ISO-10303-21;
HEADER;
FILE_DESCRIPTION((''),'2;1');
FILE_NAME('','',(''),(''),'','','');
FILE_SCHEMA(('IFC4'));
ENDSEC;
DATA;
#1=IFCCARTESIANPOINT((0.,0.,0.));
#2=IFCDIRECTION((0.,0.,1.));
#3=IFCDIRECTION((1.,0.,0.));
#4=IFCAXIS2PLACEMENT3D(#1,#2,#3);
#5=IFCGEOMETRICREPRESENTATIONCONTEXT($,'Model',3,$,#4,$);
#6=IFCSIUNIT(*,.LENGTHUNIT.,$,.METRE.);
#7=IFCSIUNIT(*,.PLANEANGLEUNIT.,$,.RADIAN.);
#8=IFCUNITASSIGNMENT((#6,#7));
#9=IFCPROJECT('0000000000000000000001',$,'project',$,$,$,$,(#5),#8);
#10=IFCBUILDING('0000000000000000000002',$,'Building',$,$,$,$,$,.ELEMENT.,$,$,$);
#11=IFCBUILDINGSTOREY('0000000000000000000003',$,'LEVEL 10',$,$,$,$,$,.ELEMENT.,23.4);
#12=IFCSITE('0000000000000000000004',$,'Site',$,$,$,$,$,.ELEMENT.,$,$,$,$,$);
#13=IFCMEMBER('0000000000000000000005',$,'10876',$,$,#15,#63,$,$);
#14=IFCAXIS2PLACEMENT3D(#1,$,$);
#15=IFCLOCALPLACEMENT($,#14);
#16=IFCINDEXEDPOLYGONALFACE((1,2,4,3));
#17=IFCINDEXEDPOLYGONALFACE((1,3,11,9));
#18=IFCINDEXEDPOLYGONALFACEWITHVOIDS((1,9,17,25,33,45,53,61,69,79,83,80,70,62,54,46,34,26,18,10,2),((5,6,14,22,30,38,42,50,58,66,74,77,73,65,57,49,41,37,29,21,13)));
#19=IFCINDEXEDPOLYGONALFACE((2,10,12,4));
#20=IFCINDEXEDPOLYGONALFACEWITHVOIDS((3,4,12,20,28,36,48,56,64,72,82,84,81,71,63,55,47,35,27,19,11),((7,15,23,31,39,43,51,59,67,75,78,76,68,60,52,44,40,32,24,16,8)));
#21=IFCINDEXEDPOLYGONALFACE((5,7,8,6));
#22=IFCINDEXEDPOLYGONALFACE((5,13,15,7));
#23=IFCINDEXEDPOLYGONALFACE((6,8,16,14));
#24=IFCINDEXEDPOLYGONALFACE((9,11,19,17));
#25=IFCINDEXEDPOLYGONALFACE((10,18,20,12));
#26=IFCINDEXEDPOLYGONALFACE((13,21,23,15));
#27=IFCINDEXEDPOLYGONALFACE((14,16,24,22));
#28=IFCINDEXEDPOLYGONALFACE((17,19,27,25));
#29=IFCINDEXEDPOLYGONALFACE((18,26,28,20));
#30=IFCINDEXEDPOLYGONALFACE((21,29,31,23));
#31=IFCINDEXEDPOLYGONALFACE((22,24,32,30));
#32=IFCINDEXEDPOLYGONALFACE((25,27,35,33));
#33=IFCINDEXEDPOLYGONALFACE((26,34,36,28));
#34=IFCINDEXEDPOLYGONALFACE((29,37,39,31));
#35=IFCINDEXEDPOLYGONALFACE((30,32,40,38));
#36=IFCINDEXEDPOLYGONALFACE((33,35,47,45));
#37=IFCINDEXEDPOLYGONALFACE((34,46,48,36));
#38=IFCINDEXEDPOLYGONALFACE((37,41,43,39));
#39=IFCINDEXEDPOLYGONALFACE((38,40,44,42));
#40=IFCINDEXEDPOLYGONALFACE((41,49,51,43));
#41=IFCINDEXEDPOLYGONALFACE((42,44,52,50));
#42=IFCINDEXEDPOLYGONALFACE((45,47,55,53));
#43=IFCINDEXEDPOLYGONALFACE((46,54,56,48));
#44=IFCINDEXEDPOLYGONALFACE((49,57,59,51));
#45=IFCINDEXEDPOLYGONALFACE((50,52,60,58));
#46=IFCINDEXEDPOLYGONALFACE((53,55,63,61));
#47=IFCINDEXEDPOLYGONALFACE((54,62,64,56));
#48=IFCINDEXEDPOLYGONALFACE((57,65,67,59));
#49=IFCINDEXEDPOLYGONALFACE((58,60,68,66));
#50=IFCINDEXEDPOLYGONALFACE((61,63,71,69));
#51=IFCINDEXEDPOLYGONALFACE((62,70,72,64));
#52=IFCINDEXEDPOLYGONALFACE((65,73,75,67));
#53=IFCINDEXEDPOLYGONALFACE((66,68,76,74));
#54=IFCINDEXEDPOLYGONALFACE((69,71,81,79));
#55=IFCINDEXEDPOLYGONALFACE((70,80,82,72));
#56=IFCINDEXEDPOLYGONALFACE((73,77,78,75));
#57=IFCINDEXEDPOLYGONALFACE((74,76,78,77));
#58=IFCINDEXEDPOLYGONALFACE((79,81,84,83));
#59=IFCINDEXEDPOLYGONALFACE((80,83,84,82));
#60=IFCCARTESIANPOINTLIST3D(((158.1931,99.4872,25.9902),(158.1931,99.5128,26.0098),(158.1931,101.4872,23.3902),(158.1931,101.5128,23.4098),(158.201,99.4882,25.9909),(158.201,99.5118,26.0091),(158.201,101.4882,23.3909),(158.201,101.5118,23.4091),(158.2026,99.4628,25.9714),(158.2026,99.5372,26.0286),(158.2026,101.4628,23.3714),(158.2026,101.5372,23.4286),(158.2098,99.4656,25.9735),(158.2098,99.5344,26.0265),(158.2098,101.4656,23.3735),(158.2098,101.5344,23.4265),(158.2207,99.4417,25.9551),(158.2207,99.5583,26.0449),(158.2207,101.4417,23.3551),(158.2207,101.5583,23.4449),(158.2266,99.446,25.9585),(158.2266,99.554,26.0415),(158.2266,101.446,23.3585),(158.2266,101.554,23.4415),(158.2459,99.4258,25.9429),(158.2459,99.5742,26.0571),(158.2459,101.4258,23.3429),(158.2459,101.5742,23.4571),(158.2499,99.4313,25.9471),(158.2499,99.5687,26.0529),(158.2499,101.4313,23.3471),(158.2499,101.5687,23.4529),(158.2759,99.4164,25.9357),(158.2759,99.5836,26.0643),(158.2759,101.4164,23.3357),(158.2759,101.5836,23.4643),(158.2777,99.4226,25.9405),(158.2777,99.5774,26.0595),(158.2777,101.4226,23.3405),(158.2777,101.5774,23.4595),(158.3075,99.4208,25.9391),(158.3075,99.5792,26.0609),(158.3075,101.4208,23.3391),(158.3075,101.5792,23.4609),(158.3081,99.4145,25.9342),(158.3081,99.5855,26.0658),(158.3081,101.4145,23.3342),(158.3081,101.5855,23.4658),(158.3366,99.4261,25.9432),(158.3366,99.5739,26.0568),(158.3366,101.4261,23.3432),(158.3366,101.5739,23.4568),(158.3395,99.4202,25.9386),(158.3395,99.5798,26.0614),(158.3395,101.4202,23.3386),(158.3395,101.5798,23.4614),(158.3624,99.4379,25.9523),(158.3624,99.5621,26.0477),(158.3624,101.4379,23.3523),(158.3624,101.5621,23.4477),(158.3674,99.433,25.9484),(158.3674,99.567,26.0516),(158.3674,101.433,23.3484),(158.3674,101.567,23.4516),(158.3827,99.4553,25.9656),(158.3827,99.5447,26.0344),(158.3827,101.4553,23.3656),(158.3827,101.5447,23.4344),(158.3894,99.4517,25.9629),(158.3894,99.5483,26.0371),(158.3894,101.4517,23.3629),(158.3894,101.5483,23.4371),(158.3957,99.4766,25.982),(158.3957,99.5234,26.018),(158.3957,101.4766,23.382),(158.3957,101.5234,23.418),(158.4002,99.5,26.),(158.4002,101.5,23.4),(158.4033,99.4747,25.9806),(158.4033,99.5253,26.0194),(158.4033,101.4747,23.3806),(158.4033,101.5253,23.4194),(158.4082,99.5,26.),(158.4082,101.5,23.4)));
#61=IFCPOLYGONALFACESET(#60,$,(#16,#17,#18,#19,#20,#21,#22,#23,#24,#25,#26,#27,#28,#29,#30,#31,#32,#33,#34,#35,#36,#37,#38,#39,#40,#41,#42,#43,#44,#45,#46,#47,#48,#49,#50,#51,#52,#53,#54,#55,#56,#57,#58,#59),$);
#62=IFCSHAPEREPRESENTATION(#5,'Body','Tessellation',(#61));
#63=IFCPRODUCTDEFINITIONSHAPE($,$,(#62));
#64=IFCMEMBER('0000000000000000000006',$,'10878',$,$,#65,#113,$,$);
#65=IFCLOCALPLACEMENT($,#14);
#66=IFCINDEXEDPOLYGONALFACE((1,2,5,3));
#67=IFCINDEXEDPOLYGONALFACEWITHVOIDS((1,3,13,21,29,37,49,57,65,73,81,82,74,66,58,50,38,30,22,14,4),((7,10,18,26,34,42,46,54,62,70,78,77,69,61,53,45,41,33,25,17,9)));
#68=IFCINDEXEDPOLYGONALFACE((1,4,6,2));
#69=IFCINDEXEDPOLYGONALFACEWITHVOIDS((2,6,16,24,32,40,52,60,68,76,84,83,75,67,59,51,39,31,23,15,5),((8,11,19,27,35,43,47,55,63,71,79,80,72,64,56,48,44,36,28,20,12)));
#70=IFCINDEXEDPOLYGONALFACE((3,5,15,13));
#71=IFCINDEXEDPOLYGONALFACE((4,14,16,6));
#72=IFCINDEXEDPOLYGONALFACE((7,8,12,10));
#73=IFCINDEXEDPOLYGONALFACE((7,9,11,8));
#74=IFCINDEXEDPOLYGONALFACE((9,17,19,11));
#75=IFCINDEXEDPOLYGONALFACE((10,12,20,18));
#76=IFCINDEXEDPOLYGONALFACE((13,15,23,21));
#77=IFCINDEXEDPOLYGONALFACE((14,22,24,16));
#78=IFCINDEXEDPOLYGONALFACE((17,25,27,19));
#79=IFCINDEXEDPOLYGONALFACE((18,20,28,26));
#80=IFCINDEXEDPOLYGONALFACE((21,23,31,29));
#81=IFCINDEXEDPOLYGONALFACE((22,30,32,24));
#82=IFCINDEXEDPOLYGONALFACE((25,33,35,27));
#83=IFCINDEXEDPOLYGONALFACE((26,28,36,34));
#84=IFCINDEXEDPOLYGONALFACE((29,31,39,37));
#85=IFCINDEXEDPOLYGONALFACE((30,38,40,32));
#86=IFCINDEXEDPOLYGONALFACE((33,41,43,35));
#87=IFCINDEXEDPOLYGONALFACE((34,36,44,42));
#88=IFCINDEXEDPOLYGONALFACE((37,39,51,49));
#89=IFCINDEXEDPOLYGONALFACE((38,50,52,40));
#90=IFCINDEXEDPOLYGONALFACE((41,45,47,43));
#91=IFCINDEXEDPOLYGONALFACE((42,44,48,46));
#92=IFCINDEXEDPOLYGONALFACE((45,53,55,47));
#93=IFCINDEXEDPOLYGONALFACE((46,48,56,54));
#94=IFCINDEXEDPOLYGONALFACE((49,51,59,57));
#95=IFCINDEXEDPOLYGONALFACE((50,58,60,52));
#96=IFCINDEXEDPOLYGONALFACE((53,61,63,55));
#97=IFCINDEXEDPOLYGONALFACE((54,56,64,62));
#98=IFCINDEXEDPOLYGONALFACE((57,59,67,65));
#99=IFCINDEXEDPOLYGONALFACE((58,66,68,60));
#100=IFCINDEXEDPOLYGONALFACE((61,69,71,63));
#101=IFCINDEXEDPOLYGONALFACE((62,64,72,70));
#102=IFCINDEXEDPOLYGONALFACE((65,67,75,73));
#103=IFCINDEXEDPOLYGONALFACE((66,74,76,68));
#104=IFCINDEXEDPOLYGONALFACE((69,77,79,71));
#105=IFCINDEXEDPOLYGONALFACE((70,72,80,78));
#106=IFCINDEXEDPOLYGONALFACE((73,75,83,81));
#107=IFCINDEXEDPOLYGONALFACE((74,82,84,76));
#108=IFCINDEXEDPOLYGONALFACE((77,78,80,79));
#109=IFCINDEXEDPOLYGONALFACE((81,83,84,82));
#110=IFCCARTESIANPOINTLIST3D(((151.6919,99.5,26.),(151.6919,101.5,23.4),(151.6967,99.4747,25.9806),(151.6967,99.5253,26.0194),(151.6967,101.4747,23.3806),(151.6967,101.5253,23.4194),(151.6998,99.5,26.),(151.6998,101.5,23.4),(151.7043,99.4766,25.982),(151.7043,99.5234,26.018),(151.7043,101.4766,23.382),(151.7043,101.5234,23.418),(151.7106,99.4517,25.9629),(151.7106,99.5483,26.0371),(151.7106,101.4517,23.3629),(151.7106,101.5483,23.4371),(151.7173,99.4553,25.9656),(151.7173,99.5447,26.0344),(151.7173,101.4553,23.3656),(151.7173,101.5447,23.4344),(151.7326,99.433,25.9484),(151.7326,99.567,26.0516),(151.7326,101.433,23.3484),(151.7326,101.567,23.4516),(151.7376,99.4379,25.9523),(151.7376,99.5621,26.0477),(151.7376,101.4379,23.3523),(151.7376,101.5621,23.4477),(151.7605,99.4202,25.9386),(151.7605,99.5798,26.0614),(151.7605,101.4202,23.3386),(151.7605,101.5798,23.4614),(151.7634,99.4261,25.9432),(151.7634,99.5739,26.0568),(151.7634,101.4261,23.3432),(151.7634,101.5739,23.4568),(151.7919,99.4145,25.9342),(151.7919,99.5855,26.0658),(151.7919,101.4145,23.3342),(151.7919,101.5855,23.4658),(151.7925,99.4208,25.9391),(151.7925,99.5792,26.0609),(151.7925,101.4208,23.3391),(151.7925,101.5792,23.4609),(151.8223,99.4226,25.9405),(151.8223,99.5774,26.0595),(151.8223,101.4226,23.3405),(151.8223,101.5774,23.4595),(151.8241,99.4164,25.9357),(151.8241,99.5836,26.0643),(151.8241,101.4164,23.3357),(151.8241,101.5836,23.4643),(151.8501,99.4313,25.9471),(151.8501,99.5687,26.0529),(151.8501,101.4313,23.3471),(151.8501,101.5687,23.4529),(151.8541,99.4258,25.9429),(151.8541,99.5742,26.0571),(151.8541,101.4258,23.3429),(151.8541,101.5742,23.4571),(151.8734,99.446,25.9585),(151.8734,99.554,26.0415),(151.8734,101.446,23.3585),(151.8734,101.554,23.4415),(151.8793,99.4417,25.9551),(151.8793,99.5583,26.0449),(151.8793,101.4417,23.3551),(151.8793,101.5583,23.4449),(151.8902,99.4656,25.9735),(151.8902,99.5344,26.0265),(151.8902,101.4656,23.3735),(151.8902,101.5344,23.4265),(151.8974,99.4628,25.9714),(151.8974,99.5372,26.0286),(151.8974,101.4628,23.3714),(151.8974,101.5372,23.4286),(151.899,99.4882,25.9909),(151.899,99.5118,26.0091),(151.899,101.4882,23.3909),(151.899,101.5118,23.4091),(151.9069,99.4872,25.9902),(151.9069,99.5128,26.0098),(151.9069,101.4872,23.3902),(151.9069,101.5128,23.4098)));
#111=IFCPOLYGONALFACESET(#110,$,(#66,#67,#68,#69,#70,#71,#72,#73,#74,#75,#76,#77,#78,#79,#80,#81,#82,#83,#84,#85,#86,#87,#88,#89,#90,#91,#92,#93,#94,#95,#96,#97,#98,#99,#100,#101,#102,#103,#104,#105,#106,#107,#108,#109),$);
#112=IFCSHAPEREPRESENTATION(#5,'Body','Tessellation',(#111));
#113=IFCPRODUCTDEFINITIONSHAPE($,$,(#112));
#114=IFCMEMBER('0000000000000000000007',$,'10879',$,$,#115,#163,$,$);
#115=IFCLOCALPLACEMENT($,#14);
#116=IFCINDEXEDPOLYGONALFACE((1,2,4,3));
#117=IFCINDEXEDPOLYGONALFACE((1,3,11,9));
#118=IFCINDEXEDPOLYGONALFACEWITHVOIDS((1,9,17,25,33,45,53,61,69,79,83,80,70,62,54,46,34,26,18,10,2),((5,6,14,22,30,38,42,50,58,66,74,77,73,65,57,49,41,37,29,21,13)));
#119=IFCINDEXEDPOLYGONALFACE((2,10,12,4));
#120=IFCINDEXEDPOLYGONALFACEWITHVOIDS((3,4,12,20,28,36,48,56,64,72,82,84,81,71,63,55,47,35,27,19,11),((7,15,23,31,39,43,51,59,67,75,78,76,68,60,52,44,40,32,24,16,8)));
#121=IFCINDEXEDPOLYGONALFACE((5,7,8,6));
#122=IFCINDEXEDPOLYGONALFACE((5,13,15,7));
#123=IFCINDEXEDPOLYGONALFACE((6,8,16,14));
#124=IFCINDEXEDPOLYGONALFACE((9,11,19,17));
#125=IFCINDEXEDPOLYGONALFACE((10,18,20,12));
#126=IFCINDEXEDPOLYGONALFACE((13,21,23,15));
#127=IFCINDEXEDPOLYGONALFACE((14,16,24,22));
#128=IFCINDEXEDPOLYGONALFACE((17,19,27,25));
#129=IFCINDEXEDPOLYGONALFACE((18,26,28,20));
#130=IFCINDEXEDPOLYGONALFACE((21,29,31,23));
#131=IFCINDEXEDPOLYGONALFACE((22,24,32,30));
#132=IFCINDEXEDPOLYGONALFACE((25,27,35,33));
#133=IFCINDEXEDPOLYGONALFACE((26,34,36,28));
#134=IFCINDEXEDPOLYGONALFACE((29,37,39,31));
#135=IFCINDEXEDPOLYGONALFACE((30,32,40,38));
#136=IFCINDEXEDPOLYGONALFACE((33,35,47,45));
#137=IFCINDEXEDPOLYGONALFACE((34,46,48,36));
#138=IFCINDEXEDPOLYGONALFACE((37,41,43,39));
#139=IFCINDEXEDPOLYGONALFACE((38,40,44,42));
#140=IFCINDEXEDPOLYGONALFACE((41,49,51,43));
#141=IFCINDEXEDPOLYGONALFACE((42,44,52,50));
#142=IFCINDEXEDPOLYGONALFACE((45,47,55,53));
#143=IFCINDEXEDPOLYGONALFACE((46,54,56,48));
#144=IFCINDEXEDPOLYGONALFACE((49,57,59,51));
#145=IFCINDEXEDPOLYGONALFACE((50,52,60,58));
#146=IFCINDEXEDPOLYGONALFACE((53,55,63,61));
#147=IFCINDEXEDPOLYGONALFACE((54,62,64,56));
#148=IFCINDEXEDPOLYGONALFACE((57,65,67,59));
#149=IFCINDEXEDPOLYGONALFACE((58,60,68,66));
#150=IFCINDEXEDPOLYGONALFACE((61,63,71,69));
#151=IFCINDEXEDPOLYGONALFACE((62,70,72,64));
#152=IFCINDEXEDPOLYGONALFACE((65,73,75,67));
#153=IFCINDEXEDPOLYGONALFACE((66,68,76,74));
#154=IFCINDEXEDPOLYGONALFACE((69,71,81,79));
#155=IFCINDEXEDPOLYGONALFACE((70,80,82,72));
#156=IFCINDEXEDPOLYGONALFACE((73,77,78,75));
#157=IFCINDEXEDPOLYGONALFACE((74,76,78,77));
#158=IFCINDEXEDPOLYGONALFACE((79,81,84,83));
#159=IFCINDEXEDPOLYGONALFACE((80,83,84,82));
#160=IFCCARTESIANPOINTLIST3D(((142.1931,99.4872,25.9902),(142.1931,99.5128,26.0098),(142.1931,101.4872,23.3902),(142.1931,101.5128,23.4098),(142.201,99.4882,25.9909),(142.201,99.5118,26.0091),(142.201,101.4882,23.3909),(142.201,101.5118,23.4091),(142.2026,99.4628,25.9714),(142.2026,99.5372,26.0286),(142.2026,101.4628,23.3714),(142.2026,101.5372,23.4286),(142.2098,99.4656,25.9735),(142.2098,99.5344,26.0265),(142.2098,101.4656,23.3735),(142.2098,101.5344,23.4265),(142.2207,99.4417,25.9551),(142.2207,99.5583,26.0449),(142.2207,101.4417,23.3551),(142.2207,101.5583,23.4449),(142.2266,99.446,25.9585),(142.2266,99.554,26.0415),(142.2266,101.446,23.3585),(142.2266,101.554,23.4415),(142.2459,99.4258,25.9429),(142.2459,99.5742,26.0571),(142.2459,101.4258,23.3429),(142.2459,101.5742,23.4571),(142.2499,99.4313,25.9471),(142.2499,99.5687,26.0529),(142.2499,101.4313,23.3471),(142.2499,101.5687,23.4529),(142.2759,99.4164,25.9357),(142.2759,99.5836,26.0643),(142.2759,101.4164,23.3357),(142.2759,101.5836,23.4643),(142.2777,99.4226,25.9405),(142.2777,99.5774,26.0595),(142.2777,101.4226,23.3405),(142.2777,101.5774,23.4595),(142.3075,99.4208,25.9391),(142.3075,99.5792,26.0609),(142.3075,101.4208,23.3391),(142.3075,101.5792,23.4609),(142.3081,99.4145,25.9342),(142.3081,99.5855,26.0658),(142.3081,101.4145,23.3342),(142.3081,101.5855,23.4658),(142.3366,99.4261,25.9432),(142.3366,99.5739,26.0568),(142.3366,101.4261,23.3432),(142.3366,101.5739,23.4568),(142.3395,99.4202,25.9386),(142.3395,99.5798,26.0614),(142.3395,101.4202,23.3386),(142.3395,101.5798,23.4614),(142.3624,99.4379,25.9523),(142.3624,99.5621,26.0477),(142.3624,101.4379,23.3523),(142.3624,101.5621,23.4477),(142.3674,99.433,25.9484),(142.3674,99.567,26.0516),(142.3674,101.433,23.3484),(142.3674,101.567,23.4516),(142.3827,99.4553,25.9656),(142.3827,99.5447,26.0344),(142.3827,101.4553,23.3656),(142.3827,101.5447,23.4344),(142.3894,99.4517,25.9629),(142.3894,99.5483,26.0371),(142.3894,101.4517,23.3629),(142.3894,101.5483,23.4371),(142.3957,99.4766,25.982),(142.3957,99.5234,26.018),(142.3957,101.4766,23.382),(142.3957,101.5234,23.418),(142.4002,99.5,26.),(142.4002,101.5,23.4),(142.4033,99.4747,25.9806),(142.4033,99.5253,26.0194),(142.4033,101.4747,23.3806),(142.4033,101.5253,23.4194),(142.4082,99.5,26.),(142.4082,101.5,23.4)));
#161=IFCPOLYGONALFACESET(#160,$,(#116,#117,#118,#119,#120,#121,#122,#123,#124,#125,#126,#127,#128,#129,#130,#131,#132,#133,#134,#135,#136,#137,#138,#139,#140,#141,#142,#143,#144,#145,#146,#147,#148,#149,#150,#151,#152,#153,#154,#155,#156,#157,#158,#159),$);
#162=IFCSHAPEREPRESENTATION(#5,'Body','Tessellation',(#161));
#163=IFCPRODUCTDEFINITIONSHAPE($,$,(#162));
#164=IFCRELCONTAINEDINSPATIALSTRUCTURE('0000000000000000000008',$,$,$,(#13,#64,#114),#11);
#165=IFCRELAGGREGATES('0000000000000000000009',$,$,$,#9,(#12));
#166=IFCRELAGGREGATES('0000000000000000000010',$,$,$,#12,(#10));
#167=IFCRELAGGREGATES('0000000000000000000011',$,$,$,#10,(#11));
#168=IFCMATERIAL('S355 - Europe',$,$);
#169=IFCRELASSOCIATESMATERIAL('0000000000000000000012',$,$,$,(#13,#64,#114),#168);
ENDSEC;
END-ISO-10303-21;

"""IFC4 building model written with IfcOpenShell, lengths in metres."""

from ifc_helpers import new_model, si_unit, frame, origin_with_axes, origin_2d_with_axis, place, context, project, spatial, hollow_circle, extrude, material, material_profile, profile_set, profile_usage, element, save


model = new_model("IFC4")

# Units and contexts
model_context = context("Model", 3, world=origin_with_axes())
ifc_project = project(units=[si_unit("LENGTHUNIT", "METRE"), si_unit("PLANEANGLEUNIT", "RADIAN")], contexts=[model_context])

# Site, building, storey
site = spatial("IfcSite", under=ifc_project, Name="Site", CompositionType="ELEMENT")
building = spatial("IfcBuilding", under=site, Name="Building", CompositionType="ELEMENT")
storey = spatial("IfcBuildingStorey", under=building, Name="LEVEL 10", CompositionType="ELEMENT", Elevation=23.4)

# Shared definitions
ifc_material = material(Name="S355 - Europe")

# Members
ifc_material_profile_1 = material_profile(ifc_material, hollow_circle(Radius=0.1081, WallThickness=0.008, at=origin_2d_with_axis()))
ifc_profile_set_1 = profile_set([ifc_material_profile_1])
ifc_profile_usage_1 = profile_usage(ifc_profile_set_1, cardinal=10)
member_1_placement = place(None, frame((158.3, 101.5, 23.4), z_axis=(0.0, -0.609711, 0.792624), x_axis=(1.0, 0.0, 0.0)))
element("IfcMember", 1, at=member_1_placement, inside=storey, material=ifc_profile_usage_1, Name="10876", context=model_context, shape_type="SweptSolid", body=[
    extrude(hollow_circle(Radius=0.1081, WallThickness=0.008, at=origin_2d_with_axis()), origin_with_axes(), (0.0, 0.0, 1.0), 3.2802),
])
ifc_material_profile_2 = material_profile(ifc_material, hollow_circle(Radius=0.1081, WallThickness=0.008, at=origin_2d_with_axis()))
ifc_profile_set_2 = profile_set([ifc_material_profile_2])
ifc_profile_usage_2 = profile_usage(ifc_profile_set_2, cardinal=10)
member_2_placement = place(None, frame((151.8, 99.5, 26.0), z_axis=(0.0, 0.609711, -0.792624), x_axis=(-1.0, 0.0, 0.0)))
element("IfcMember", 2, at=member_2_placement, inside=storey, material=ifc_profile_usage_2, Name="10878", context=model_context, shape_type="SweptSolid", body=[
    extrude(hollow_circle(Radius=0.1081, WallThickness=0.008, at=origin_2d_with_axis()), origin_with_axes(), (0.0, 0.0, 1.0), 3.2802),
])
ifc_material_profile_3 = material_profile(ifc_material, hollow_circle(Radius=0.1081, WallThickness=0.008, at=origin_2d_with_axis()))
ifc_profile_set_3 = profile_set([ifc_material_profile_3])
ifc_profile_usage_3 = profile_usage(ifc_profile_set_3, cardinal=10)
member_3_placement = place(None, frame((142.3, 101.5, 23.4), z_axis=(0.0, -0.609711, 0.792624), x_axis=(1.0, 0.0, 0.0)))
element("IfcMember", 3, at=member_3_placement, inside=storey, material=ifc_profile_usage_3, Name="10879", context=model_context, shape_type="SweptSolid", body=[
    extrude(hollow_circle(Radius=0.1081, WallThickness=0.008, at=origin_2d_with_axis()), origin_with_axes(), (0.0, 0.0, 1.0), 3.2802),
])

save(model, "model.ifc")
